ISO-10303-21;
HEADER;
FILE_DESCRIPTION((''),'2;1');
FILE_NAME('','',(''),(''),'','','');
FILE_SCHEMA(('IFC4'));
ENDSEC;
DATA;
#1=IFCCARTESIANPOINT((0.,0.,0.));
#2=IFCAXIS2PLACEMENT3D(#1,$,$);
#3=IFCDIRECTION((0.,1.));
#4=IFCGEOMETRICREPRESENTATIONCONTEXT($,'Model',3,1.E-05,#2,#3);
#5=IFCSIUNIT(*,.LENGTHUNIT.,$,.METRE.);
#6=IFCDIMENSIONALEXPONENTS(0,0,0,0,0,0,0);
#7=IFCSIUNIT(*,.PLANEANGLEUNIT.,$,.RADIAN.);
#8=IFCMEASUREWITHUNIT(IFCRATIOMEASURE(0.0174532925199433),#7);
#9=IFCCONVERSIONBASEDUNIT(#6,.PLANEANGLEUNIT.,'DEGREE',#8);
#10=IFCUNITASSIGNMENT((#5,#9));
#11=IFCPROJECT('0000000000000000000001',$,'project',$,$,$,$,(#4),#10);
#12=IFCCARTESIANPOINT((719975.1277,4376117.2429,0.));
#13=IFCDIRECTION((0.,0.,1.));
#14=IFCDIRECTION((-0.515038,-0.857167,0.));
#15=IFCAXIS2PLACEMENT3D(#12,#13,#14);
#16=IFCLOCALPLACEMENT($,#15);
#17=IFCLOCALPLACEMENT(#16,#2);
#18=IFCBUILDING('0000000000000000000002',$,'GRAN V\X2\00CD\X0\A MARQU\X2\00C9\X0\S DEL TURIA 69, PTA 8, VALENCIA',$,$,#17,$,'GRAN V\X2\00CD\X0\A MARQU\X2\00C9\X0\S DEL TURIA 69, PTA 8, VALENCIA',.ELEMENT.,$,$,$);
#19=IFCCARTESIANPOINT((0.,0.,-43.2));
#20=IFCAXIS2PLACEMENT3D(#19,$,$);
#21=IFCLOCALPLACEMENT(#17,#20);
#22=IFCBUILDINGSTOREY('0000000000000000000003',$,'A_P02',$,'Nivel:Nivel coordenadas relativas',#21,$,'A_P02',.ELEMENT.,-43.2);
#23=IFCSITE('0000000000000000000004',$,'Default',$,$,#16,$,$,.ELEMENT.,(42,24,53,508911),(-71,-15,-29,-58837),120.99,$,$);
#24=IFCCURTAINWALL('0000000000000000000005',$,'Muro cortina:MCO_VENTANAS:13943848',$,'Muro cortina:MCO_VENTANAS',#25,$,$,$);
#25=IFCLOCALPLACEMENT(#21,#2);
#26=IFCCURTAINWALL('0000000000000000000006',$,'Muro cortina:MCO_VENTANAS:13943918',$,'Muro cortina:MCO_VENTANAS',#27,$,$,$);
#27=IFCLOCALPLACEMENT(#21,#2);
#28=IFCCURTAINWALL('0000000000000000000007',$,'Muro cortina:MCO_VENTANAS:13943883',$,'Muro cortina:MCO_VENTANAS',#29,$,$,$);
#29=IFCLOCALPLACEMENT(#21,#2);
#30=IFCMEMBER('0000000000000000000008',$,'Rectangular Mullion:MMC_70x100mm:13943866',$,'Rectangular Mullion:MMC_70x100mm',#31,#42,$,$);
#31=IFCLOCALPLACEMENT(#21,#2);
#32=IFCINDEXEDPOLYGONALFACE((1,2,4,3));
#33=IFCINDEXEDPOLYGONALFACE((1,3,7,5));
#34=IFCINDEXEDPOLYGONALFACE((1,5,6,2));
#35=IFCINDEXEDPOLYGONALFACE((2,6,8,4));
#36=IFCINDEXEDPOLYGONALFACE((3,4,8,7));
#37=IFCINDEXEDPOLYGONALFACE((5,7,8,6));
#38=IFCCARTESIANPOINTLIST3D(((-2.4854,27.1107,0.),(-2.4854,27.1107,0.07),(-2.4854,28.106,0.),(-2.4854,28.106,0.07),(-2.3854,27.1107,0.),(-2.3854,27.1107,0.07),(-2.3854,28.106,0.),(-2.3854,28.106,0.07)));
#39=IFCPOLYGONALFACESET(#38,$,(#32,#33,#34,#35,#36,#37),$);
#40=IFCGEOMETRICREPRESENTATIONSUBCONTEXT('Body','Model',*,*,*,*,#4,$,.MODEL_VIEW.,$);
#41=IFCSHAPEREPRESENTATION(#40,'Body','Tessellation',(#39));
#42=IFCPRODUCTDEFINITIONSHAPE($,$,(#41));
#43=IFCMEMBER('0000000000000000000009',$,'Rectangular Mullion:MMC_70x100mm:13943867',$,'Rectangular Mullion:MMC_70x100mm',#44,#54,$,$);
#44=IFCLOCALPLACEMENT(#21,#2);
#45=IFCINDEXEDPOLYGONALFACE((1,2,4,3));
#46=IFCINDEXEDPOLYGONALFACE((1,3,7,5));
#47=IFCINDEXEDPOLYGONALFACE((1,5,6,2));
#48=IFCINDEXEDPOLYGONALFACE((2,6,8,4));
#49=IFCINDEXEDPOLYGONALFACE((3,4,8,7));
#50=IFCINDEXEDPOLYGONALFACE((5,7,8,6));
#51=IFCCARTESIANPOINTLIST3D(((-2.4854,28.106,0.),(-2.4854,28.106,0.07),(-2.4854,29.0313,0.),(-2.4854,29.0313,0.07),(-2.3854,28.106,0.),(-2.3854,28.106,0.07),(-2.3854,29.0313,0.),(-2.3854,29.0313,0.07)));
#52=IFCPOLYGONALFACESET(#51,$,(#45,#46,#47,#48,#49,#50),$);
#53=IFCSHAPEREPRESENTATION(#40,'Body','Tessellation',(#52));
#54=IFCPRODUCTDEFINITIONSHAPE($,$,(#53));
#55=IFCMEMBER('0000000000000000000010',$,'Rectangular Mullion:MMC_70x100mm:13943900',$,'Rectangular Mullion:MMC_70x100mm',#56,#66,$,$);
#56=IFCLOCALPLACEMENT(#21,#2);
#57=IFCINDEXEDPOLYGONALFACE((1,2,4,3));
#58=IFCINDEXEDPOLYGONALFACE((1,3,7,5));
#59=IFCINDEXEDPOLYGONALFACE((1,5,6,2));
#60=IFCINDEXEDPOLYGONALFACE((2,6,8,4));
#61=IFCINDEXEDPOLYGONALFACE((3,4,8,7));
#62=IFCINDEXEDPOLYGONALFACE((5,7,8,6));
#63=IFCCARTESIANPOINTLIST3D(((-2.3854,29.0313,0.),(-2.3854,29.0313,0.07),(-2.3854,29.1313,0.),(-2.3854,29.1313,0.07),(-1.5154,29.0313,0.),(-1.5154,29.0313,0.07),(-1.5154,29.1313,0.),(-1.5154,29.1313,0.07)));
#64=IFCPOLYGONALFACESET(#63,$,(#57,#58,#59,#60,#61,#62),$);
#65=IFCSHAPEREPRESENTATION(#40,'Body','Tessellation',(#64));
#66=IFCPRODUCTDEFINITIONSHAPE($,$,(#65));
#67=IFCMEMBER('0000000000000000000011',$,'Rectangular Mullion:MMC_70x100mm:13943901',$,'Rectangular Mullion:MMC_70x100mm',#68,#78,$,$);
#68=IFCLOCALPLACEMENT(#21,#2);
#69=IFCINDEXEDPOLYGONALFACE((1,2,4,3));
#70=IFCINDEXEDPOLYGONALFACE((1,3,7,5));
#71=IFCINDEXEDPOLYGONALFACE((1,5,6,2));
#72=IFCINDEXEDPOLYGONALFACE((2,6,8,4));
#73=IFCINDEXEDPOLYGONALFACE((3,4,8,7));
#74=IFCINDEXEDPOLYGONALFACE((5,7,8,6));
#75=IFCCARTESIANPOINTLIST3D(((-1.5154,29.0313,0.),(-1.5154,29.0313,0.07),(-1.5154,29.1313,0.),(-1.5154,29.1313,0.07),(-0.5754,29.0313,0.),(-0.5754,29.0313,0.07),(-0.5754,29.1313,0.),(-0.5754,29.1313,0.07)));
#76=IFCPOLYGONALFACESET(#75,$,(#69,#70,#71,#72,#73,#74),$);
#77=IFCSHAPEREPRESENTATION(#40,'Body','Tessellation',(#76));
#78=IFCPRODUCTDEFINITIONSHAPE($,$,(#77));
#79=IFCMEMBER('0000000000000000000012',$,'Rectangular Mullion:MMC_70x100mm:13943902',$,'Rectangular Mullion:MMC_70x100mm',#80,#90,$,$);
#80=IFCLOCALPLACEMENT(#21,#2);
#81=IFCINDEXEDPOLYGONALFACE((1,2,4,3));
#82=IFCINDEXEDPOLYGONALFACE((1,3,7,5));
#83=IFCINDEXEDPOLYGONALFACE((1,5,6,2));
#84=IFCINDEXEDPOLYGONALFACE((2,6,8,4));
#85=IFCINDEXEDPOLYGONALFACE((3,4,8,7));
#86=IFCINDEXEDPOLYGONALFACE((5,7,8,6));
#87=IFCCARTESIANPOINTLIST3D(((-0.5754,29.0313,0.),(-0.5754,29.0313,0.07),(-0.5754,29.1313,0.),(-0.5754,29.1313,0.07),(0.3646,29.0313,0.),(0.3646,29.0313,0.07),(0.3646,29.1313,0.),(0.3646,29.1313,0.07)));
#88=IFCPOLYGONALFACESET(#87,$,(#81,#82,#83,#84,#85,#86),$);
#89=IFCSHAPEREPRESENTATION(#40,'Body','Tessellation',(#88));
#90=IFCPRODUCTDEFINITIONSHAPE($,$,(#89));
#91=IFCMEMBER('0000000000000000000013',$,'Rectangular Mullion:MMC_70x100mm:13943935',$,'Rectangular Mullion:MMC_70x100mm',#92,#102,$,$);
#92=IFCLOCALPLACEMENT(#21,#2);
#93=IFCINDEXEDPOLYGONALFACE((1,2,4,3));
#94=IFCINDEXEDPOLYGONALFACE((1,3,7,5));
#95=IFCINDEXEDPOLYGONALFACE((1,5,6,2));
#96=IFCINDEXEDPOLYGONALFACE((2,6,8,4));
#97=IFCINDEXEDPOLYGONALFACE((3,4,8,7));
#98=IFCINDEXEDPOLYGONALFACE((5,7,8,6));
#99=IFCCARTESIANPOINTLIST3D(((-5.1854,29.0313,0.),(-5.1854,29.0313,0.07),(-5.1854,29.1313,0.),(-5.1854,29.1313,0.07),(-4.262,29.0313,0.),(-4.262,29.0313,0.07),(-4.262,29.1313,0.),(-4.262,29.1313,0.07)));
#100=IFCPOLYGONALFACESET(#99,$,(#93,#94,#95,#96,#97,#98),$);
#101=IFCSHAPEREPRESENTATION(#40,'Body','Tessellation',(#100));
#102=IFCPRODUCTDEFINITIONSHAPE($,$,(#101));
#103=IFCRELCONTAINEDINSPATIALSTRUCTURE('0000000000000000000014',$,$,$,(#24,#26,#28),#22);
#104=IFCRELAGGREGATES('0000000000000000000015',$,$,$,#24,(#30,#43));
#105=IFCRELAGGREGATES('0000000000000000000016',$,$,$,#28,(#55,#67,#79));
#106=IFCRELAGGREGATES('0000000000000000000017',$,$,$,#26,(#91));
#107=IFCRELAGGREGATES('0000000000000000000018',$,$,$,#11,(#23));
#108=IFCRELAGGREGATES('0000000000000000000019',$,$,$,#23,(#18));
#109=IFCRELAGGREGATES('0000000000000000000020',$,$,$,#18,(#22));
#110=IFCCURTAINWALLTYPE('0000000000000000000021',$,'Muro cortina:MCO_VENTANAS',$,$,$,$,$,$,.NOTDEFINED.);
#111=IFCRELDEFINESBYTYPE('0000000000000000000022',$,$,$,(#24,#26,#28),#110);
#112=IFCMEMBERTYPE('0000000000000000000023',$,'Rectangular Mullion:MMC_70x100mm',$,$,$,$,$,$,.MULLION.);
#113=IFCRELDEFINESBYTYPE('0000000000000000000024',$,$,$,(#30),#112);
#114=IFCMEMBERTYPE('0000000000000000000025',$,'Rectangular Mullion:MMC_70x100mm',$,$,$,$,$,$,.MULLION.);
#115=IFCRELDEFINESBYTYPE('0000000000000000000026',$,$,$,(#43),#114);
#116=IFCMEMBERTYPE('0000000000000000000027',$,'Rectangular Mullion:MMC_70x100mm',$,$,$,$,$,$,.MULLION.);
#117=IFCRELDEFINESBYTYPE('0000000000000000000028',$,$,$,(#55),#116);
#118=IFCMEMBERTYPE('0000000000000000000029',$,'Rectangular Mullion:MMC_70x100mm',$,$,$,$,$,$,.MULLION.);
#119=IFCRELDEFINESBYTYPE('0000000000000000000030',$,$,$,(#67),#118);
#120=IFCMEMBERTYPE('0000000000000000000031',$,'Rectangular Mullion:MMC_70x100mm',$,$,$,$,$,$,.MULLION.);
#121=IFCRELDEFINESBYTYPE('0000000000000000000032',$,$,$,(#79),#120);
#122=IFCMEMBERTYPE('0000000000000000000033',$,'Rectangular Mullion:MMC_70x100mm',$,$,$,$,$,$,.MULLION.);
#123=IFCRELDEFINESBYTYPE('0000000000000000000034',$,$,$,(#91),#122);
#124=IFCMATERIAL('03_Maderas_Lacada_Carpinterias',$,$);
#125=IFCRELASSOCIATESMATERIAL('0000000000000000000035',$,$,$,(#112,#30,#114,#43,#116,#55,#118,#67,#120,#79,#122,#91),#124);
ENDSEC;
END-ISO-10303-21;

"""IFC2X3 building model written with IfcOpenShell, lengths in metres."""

from ifc_helpers import new_model, entity, si_unit, converted_unit, direction, frame, origin, origin_2d_with_axis, place, context, subcontext, project, spatial, rectangle, extrude, source, transform, mapped, material, type_object, type_shapes, element, aggregate, save


model = new_model("IFC2X3")

# Units and contexts
model_context = context("Model", 3, precision=1e-05, world=origin(), true_north=direction((0.0, 1.0)))
body_context = subcontext(model_context, "Body", "Model", "MODEL_VIEW")
ifc_project = project(units=[si_unit("LENGTHUNIT", "METRE"), converted_unit("PLANEANGLEUNIT", "DEGREE", entity("IfcRatioMeasure", 0.0174532925199433), si_unit("PLANEANGLEUNIT", "RADIAN"), dimensions=[0, 0, 0, 0, 0, 0, 0])], contexts=[model_context])

# Site, building, storey
site_placement = place(None, frame((719975.1277, 4376117.2429, 0.0), z_axis=(0.0, 0.0, 1.0), x_axis=(-0.515038, -0.857167, 0.0)))
site = spatial("IfcSite", under=ifc_project, at=site_placement, Name="Default", CompositionType="ELEMENT", RefLatitude=(42, 24, 53, 508911), RefLongitude=(-71, -15, -29, -58837), RefElevation=120.99)
building_placement = place(site_placement, origin())
building = spatial("IfcBuilding", under=site, at=building_placement, Name="GRAN VÍA MARQUÉS DEL TURIA 69, PTA 8, VALENCIA", LongName="GRAN VÍA MARQUÉS DEL TURIA 69, PTA 8, VALENCIA", CompositionType="ELEMENT")
storey_placement = place(building_placement, frame((0.0, 0.0, -43.2)))
storey = spatial("IfcBuildingStorey", under=building, at=storey_placement, Name="A_P02", ObjectType="Nivel:Nivel coordenadas relativas", LongName="A_P02", CompositionType="ELEMENT", Elevation=-43.2)

# Curtain walls
curtain_wall_type = type_object("IfcCurtainWallType", Name="Muro cortina:MCO_VENTANAS", PredefinedType="NOTDEFINED")
ifc_material_1 = material(Name="03_Maderas_Lacada_Carpinterias")
curtain_wall_1_placement = place(storey_placement, frame((0.0, 0.0, 43.2)))
curtain_wall_1 = element("IfcCurtainWall", 1, at=curtain_wall_1_placement, inside=storey, type_object=curtain_wall_type, Name="Muro cortina:MCO_VENTANAS:13943848", ObjectType="Muro cortina:MCO_VENTANAS")
curtain_wall_2_placement = place(storey_placement, frame((0.0, 0.0, 43.2)))
curtain_wall_2 = element("IfcCurtainWall", 2, at=curtain_wall_2_placement, inside=storey, type_object=curtain_wall_type, Name="Muro cortina:MCO_VENTANAS:13943918", ObjectType="Muro cortina:MCO_VENTANAS")

# Curtain wall
curtain_wall_3_placement = place(storey_placement, frame((0.0, 0.0, 43.2)))
curtain_wall_3 = element("IfcCurtainWall", 3, at=curtain_wall_3_placement, inside=storey, type_object=curtain_wall_type, Name="Muro cortina:MCO_VENTANAS:13943883", ObjectType="Muro cortina:MCO_VENTANAS")

# Members
member_type_1 = type_object("IfcMemberType", Name="Rectangular Mullion:MMC_70x100mm", PredefinedType="MULLION", material=ifc_material_1)
shared_shape_1 = source(origin(), body_context, "Body", "SweptSolid", [
    extrude(rectangle(XDim=0.1, YDim=0.07, at=origin_2d_with_axis()), frame((-0.035, 0.0, -0.9953), z_axis=(0.0, 0.0, 1.0), x_axis=(0.0, -1.0, 0.0)), (0.0, 0.0, 1.0), 0.9953),
])
type_shapes(member_type_1, [shared_shape_1])
member_1_placement = place(storey_placement, frame((-2.4354, 27.1107, 0.0), z_axis=(0.0, -1.0, 0.0), x_axis=(0.0, 0.0, -1.0)))
member_1 = element("IfcMember", 4, at=member_1_placement, type_object=member_type_1, material=ifc_material_1, Name="Rectangular Mullion:MMC_70x100mm:13943866", ObjectType="Rectangular Mullion:MMC_70x100mm", context=body_context, shape_type="MappedRepresentation", body=[
    mapped(shared_shape_1, transform((0.0, 0.0, 0.0), scale=1.0)),
])
member_type_2 = type_object("IfcMemberType", Name="Rectangular Mullion:MMC_70x100mm", PredefinedType="MULLION", material=ifc_material_1)
shared_shape_2 = source(origin(), body_context, "Body", "SweptSolid", [
    extrude(rectangle(XDim=0.1, YDim=0.07, at=origin_2d_with_axis()), frame((-0.035, 0.0, -0.9253), z_axis=(0.0, 0.0, 1.0), x_axis=(0.0, -1.0, 0.0)), (0.0, 0.0, 1.0), 0.9253),
])
type_shapes(member_type_2, [shared_shape_2])
member_2_placement = place(storey_placement, frame((-2.4354, 28.106, 0.0), z_axis=(0.0, -1.0, 0.0), x_axis=(0.0, 0.0, -1.0)))
member_2 = element("IfcMember", 5, at=member_2_placement, type_object=member_type_2, material=ifc_material_1, Name="Rectangular Mullion:MMC_70x100mm:13943867", ObjectType="Rectangular Mullion:MMC_70x100mm", context=body_context, shape_type="MappedRepresentation", body=[
    mapped(shared_shape_2, transform((0.0, 0.0, 0.0), scale=1.0)),
])
member_type_3 = type_object("IfcMemberType", Name="Rectangular Mullion:MMC_70x100mm", PredefinedType="MULLION", material=ifc_material_1)
shared_shape_3 = source(origin(), body_context, "Body", "SweptSolid", [
    extrude(rectangle(XDim=0.1, YDim=0.07, at=origin_2d_with_axis()), frame((-0.035, 0.0, -0.87), z_axis=(0.0, 0.0, 1.0), x_axis=(0.0, -1.0, 0.0)), (0.0, 0.0, 1.0), 0.87),
])
type_shapes(member_type_3, [shared_shape_3])
member_3_placement = place(storey_placement, frame((-2.3854, 29.0813, 0.0), z_axis=(-1.0, 0.0, 0.0), x_axis=(0.0, 0.0, -1.0)))
member_3 = element("IfcMember", 6, at=member_3_placement, type_object=member_type_3, material=ifc_material_1, Name="Rectangular Mullion:MMC_70x100mm:13943900", ObjectType="Rectangular Mullion:MMC_70x100mm", context=body_context, shape_type="MappedRepresentation", body=[
    mapped(shared_shape_3, transform((0.0, 0.0, 0.0), scale=1.0)),
])
member_type_4 = type_object("IfcMemberType", Name="Rectangular Mullion:MMC_70x100mm", PredefinedType="MULLION", material=ifc_material_1)
shared_shape_4 = source(origin(), body_context, "Body", "SweptSolid", [
    extrude(rectangle(XDim=0.1, YDim=0.07, at=origin_2d_with_axis()), frame((-0.035, 0.0, -0.94), z_axis=(0.0, 0.0, 1.0), x_axis=(0.0, -1.0, 0.0)), (0.0, 0.0, 1.0), 0.94),
])
type_shapes(member_type_4, [shared_shape_4])
member_4_placement = place(storey_placement, frame((-1.5154, 29.0813, 0.0), z_axis=(-1.0, 0.0, 0.0), x_axis=(0.0, 0.0, -1.0)))
member_4 = element("IfcMember", 7, at=member_4_placement, type_object=member_type_4, material=ifc_material_1, Name="Rectangular Mullion:MMC_70x100mm:13943901", ObjectType="Rectangular Mullion:MMC_70x100mm", context=body_context, shape_type="MappedRepresentation", body=[
    mapped(shared_shape_4, transform((0.0, 0.0, 0.0), scale=1.0)),
])
member_type_5 = type_object("IfcMemberType", Name="Rectangular Mullion:MMC_70x100mm", PredefinedType="MULLION", material=ifc_material_1)
shared_shape_5 = source(origin(), body_context, "Body", "SweptSolid", [
    extrude(rectangle(XDim=0.1, YDim=0.07, at=origin_2d_with_axis()), frame((-0.035, 0.0, -0.94), z_axis=(0.0, 0.0, 1.0), x_axis=(0.0, -1.0, 0.0)), (0.0, 0.0, 1.0), 0.94),
])
type_shapes(member_type_5, [shared_shape_5])
member_5_placement = place(storey_placement, frame((-0.5754, 29.0813, 0.0), z_axis=(-1.0, 0.0, 0.0), x_axis=(0.0, 0.0, -1.0)))
member_5 = element("IfcMember", 8, at=member_5_placement, type_object=member_type_5, material=ifc_material_1, Name="Rectangular Mullion:MMC_70x100mm:13943902", ObjectType="Rectangular Mullion:MMC_70x100mm", context=body_context, shape_type="MappedRepresentation", body=[
    mapped(shared_shape_5, transform((0.0, 0.0, 0.0), scale=1.0)),
])
member_type_6 = type_object("IfcMemberType", Name="Rectangular Mullion:MMC_70x100mm", PredefinedType="MULLION", material=ifc_material_1)
shared_shape_6 = source(origin(), body_context, "Body", "SweptSolid", [
    extrude(rectangle(XDim=0.1, YDim=0.07, at=origin_2d_with_axis()), frame((-0.035, 0.0, -0.9233), z_axis=(0.0, 0.0, 1.0), x_axis=(0.0, -1.0, 0.0)), (0.0, 0.0, 1.0), 0.9233),
])
type_shapes(member_type_6, [shared_shape_6])
member_6_placement = place(storey_placement, frame((-5.1854, 29.0813, 0.0), z_axis=(-1.0, 0.0, 0.0), x_axis=(0.0, 0.0, -1.0)))
member_6 = element("IfcMember", 9, at=member_6_placement, type_object=member_type_6, material=ifc_material_1, Name="Rectangular Mullion:MMC_70x100mm:13943935", ObjectType="Rectangular Mullion:MMC_70x100mm", context=body_context, shape_type="MappedRepresentation", body=[
    mapped(shared_shape_6, transform((0.0, 0.0, 0.0), scale=1.0)),
])

aggregate(curtain_wall_1, [member_1, member_2])
aggregate(curtain_wall_3, [member_3, member_4, member_5])
aggregate(curtain_wall_2, [member_6])

save(model, "model.ifc")
